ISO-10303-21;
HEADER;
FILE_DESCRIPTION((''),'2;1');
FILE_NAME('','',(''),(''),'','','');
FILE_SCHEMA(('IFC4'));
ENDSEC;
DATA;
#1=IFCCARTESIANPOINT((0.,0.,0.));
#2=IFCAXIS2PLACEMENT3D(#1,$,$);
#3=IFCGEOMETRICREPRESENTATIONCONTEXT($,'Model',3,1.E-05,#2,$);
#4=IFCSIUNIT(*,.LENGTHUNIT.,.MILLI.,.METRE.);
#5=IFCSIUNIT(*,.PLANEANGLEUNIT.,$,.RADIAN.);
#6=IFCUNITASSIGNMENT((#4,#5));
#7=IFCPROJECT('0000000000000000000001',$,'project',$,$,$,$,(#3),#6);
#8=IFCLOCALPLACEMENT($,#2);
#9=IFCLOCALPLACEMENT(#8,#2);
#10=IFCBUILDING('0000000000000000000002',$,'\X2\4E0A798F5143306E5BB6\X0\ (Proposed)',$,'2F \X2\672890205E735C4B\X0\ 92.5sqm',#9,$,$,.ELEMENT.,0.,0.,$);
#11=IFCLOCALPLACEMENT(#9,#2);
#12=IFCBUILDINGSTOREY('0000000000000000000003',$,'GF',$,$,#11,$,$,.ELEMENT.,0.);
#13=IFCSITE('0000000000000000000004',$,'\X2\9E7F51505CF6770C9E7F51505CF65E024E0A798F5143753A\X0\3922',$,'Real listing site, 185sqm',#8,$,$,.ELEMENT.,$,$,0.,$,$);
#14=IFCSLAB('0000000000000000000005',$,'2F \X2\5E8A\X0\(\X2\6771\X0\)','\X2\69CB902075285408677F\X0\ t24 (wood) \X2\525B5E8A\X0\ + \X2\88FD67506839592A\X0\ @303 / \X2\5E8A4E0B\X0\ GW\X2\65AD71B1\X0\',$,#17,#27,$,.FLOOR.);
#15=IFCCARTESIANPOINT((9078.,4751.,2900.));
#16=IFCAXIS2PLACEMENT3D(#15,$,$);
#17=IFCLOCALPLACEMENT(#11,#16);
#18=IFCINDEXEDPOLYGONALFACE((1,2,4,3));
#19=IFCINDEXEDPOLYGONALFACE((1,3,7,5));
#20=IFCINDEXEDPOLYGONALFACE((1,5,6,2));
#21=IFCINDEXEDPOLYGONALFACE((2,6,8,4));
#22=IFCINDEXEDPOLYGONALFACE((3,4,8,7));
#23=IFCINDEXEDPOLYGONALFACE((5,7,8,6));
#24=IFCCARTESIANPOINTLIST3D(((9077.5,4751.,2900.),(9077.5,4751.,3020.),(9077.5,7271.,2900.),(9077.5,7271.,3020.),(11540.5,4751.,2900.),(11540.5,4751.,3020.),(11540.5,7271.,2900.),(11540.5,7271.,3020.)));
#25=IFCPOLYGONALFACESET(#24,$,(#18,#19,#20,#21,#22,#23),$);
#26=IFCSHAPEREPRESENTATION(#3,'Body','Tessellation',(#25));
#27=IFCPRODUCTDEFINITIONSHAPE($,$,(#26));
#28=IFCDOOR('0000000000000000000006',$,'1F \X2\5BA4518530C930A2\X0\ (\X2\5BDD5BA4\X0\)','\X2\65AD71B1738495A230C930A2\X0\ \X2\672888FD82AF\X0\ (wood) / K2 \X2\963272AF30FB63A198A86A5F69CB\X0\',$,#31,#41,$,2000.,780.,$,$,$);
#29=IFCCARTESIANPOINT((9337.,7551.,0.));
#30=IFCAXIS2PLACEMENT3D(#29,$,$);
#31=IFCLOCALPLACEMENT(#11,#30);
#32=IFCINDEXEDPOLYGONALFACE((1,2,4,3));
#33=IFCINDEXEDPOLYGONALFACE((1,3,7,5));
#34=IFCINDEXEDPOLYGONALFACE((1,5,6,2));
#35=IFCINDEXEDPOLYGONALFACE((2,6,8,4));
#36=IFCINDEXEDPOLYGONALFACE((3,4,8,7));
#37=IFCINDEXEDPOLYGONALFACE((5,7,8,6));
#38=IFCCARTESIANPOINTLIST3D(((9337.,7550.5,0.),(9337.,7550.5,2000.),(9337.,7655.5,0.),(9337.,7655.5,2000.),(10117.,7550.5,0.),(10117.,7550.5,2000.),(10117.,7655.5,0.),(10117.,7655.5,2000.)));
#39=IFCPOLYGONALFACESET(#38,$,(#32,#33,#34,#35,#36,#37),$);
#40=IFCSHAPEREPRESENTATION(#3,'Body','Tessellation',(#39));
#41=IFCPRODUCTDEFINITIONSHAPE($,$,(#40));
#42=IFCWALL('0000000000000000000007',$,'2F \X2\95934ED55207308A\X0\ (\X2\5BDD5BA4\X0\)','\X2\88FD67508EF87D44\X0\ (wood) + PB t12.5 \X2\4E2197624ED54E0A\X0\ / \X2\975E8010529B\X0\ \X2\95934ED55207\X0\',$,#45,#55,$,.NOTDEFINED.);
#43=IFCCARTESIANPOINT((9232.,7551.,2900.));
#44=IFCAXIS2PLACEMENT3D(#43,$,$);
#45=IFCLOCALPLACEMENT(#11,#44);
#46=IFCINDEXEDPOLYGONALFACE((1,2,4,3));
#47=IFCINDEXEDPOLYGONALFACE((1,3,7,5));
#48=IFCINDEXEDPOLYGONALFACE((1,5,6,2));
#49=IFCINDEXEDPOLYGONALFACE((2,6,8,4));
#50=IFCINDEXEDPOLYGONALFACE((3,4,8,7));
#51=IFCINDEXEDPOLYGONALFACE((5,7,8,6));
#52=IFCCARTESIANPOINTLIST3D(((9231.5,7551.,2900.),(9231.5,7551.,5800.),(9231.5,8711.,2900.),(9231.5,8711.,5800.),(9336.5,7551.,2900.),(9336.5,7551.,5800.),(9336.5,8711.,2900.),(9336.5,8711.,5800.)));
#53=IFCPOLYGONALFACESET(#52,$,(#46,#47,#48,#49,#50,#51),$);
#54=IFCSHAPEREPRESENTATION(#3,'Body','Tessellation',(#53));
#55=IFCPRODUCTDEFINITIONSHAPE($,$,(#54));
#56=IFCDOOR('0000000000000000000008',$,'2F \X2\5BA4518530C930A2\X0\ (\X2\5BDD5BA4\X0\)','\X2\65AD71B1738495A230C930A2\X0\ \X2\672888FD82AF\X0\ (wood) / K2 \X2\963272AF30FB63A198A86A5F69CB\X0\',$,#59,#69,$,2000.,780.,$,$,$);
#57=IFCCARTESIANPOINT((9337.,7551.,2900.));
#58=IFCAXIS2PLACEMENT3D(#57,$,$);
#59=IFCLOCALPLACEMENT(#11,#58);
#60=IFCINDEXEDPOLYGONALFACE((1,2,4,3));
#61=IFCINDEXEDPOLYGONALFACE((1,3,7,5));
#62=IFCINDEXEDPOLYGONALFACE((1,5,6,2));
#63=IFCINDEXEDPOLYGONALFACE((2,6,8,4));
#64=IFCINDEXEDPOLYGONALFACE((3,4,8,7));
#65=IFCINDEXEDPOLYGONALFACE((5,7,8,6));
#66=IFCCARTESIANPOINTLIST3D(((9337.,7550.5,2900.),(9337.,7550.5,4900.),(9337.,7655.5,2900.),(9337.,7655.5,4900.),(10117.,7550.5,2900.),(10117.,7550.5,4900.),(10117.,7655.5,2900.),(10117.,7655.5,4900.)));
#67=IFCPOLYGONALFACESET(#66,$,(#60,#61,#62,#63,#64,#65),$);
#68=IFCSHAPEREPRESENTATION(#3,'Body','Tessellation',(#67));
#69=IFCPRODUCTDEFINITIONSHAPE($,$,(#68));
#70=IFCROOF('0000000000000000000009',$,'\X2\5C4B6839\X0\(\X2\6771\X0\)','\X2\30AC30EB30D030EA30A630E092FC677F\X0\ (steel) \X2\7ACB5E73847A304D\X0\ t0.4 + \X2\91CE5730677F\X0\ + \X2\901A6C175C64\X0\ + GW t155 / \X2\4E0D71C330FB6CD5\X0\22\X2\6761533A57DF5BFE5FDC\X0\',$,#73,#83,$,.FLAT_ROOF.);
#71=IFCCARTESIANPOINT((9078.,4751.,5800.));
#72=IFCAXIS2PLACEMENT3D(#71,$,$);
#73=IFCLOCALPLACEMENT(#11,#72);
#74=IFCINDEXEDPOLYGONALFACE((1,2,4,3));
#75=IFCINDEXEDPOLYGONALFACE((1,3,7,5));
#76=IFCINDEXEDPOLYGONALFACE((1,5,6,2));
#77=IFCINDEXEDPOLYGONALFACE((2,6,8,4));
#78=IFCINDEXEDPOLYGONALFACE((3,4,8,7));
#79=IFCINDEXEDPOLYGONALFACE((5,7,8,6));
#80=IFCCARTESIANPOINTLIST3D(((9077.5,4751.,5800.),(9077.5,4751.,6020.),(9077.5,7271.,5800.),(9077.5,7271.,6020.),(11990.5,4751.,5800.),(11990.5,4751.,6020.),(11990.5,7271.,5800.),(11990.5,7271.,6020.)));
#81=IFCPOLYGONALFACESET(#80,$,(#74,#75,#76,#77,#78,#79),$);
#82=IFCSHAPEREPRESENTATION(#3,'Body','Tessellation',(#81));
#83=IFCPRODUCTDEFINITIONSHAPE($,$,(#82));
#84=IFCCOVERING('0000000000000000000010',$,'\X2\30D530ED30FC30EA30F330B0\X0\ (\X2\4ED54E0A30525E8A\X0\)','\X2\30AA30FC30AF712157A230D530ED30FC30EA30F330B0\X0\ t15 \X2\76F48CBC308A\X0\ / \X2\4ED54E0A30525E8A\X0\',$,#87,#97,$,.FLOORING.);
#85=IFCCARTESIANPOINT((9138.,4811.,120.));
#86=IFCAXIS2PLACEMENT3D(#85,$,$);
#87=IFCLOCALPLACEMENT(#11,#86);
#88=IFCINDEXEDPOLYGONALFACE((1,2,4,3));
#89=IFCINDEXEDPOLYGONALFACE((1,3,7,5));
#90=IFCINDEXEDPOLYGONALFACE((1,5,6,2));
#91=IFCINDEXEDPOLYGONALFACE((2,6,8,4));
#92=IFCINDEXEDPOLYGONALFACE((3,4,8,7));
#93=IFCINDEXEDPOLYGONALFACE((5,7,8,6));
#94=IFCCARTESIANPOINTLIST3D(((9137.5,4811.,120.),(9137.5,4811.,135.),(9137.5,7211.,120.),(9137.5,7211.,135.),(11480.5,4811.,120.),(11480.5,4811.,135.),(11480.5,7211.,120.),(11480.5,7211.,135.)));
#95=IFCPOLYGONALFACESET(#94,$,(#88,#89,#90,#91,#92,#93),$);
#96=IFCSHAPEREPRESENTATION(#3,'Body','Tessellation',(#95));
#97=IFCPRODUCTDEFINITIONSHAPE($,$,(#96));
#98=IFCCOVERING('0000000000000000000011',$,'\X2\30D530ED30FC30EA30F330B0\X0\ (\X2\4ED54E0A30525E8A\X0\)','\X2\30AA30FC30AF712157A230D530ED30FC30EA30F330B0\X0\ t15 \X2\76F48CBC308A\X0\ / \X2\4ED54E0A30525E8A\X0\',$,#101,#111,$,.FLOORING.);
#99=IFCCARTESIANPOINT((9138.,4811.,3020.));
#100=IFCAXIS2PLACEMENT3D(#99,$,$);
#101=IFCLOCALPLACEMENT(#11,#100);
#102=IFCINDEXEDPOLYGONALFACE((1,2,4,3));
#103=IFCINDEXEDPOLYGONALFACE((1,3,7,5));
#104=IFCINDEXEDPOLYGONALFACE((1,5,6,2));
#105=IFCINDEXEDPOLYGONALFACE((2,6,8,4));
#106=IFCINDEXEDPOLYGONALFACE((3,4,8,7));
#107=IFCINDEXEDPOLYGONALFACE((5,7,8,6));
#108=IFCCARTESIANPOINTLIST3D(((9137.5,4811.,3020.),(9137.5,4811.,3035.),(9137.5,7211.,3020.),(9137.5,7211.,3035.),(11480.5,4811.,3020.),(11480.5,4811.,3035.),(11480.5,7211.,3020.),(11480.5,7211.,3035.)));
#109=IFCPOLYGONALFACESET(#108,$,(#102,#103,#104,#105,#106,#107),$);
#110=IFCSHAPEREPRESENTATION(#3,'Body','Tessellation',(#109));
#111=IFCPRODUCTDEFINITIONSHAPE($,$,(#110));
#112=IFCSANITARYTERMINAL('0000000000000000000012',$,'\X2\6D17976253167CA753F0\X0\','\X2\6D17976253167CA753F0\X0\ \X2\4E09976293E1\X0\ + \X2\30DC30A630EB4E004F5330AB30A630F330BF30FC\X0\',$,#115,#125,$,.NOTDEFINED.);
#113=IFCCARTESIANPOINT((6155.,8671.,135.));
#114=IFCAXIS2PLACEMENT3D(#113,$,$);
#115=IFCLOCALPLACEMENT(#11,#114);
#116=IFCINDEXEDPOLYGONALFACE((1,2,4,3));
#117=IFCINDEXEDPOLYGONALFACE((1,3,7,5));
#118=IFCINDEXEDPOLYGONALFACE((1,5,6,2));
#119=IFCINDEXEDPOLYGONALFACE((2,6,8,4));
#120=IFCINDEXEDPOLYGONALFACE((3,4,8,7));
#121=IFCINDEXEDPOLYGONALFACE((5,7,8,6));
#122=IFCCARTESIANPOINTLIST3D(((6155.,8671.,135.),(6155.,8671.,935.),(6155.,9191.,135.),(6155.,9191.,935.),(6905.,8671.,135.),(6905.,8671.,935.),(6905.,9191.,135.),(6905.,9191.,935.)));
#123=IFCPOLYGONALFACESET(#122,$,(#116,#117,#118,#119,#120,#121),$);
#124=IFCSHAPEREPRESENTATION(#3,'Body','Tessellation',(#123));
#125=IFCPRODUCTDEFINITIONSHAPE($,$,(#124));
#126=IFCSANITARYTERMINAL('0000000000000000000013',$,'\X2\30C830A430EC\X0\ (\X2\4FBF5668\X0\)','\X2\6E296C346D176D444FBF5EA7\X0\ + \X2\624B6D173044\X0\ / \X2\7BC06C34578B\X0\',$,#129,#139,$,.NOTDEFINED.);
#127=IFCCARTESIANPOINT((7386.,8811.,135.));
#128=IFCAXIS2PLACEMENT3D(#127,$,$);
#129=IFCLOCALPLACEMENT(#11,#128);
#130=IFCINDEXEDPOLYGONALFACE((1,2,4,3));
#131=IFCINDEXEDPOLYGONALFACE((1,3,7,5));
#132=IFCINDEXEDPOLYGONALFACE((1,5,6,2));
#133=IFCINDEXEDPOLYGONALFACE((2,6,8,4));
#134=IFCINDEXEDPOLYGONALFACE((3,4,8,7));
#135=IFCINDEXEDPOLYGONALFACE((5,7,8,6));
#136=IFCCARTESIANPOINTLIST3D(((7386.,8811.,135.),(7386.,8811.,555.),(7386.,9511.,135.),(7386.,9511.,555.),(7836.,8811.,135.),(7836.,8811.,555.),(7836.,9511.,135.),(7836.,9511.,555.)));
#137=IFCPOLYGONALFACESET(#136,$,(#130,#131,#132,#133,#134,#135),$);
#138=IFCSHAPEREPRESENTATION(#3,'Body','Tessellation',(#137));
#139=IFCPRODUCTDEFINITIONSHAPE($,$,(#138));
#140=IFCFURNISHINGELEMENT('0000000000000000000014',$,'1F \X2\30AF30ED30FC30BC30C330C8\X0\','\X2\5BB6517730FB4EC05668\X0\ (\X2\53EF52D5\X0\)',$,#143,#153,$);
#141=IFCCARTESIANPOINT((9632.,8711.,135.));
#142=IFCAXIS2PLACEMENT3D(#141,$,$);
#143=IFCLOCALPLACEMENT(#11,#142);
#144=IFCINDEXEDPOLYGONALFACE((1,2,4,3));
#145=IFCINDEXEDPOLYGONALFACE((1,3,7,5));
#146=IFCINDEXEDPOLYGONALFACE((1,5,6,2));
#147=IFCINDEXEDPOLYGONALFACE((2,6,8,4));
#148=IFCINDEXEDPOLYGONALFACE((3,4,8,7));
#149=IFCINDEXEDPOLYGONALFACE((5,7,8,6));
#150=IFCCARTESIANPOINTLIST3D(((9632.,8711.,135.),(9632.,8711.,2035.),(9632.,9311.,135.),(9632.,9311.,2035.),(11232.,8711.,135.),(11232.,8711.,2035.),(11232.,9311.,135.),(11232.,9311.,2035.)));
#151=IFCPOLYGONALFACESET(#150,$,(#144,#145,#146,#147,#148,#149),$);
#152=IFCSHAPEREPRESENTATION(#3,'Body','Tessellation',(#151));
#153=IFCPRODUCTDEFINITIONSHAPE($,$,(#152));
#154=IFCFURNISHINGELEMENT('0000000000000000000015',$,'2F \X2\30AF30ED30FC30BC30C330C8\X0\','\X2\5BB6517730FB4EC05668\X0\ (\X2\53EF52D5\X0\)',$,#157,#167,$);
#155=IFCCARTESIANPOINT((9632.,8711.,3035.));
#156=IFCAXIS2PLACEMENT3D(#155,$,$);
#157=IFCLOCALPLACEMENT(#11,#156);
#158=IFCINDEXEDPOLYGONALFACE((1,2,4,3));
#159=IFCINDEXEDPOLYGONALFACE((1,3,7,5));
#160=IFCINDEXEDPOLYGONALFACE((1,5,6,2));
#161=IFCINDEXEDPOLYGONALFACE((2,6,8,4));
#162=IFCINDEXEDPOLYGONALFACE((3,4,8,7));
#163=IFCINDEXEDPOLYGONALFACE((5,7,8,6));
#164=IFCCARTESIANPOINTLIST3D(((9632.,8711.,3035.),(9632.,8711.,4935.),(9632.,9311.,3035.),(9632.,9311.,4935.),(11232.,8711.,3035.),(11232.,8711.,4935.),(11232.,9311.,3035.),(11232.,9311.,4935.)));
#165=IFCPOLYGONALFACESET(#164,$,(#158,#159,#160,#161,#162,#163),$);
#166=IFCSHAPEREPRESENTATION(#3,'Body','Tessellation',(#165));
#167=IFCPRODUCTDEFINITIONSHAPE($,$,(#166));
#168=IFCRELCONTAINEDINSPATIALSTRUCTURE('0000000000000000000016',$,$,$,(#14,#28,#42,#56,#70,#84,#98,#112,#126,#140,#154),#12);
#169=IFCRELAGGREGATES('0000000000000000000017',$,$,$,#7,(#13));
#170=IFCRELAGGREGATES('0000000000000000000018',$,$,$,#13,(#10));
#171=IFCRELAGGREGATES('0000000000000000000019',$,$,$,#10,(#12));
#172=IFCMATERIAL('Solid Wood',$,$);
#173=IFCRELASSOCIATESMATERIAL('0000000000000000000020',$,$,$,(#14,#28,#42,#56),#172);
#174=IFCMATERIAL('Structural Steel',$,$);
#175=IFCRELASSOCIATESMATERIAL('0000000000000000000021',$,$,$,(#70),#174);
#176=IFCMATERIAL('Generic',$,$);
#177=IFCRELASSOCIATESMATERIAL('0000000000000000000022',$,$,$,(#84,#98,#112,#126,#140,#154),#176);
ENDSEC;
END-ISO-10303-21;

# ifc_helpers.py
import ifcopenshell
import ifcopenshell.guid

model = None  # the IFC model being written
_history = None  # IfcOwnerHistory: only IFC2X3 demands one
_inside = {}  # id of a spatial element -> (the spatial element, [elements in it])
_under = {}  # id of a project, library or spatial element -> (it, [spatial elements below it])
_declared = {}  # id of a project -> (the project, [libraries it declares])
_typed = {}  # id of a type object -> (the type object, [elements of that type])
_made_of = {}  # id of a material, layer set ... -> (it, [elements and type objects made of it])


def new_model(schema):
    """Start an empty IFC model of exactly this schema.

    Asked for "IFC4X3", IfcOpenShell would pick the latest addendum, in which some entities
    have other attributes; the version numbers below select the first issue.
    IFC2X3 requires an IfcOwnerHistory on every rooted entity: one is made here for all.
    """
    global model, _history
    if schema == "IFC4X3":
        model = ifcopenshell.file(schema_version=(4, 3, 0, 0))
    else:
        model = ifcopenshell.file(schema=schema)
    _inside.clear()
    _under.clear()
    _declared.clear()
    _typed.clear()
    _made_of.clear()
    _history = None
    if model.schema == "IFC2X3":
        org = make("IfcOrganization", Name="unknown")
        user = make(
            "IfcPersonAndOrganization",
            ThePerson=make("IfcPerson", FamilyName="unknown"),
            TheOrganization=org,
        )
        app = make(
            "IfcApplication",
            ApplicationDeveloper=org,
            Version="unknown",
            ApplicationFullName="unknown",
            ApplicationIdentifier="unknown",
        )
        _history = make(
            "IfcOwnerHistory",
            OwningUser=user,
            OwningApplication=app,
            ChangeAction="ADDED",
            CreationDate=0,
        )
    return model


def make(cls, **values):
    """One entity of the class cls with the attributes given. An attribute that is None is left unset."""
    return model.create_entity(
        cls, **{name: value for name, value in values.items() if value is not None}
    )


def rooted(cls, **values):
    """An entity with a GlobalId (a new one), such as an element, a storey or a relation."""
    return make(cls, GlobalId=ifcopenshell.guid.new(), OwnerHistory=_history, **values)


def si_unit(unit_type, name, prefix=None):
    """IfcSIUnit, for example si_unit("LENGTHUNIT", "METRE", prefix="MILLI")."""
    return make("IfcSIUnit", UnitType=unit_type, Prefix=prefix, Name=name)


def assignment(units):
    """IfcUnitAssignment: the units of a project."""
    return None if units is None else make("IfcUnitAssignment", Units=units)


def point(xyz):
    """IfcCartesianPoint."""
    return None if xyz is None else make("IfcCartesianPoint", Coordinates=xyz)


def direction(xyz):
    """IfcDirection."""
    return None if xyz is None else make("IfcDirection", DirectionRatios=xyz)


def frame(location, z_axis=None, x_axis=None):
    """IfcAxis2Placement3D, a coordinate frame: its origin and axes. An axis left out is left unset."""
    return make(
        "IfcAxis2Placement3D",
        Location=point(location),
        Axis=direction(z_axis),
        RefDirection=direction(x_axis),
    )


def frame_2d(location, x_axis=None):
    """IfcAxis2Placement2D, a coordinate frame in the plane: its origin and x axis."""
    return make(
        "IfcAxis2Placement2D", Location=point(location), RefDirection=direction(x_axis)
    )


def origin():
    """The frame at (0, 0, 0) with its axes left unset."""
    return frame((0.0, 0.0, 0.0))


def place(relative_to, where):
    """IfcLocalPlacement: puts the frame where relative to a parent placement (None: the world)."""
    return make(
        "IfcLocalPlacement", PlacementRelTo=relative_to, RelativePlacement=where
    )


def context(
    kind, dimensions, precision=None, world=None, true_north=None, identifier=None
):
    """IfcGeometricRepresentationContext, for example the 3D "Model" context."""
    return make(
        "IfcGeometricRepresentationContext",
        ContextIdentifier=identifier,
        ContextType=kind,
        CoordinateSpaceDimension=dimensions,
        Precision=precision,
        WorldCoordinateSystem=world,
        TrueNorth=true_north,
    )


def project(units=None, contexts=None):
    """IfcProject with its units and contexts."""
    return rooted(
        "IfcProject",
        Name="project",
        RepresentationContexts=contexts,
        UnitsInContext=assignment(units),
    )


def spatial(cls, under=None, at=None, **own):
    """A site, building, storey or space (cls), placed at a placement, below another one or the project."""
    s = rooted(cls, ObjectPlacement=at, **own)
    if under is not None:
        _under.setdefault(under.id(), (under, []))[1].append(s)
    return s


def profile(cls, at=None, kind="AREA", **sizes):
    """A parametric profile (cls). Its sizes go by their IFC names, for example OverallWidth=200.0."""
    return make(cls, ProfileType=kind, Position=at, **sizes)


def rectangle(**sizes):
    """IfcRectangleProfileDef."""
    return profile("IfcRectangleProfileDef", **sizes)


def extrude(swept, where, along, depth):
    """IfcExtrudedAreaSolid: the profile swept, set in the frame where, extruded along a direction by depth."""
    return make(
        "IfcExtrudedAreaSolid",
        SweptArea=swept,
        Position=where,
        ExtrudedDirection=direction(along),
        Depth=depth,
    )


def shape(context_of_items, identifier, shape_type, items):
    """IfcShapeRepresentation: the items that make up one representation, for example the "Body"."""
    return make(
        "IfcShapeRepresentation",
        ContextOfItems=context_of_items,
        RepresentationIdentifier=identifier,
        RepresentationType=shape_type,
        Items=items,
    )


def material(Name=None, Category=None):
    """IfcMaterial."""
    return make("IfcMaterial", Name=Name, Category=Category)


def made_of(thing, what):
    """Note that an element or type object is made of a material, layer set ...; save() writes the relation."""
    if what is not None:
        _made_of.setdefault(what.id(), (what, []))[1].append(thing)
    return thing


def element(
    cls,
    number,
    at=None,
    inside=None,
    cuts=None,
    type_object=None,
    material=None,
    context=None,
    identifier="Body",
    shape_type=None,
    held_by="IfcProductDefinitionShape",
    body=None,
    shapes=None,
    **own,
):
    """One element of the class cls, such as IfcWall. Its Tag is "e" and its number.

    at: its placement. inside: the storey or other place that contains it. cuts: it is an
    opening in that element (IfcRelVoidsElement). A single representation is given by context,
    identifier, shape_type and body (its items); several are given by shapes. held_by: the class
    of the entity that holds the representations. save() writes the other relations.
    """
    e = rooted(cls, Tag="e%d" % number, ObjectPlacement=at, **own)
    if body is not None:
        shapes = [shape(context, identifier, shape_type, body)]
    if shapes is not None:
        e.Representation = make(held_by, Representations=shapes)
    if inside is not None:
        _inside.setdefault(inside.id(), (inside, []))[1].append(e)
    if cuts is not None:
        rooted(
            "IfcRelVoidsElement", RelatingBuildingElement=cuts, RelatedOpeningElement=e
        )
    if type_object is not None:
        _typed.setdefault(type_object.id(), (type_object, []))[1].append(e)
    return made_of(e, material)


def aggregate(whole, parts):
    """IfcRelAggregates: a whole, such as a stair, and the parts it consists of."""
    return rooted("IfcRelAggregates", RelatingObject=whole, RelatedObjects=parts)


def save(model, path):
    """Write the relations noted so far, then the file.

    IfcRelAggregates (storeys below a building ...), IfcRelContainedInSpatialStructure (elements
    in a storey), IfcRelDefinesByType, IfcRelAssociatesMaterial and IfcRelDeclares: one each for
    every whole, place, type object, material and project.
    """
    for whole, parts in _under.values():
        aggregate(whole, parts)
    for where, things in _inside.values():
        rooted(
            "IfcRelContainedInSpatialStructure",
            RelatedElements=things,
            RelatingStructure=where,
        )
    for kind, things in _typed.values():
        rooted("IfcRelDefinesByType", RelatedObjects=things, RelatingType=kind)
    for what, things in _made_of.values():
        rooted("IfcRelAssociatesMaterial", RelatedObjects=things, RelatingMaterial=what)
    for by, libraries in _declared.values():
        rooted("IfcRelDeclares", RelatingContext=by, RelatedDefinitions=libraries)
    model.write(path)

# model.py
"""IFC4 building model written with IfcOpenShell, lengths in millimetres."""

from ifc_helpers import new_model, si_unit, frame, frame_2d, origin, place, context, project, spatial, rectangle, extrude, material, element, save


model = new_model("IFC4")

# Units and contexts
model_context = context("Model", 3, precision=1e-05, world=origin())
ifc_project = project(units=[si_unit("LENGTHUNIT", "METRE", prefix="MILLI"), si_unit("PLANEANGLEUNIT", "RADIAN")], contexts=[model_context])

# Site, building, storey
site_placement = place(None, origin())
site = spatial("IfcSite", under=ifc_project, at=site_placement, Name="鹿児島県鹿児島市上福元町3922", ObjectType="Real listing site, 185sqm", CompositionType="ELEMENT", RefElevation=0.0)
building_placement = place(site_placement, origin())
building = spatial("IfcBuilding", under=site, at=building_placement, Name="上福元の家 (Proposed)", ObjectType="2F 木造平屋 92.5sqm", CompositionType="ELEMENT", ElevationOfRefHeight=0.0, ElevationOfTerrain=0.0)
storey_placement = place(building_placement, origin())
storey = spatial("IfcBuildingStorey", under=building, at=storey_placement, Name="GF", CompositionType="ELEMENT", Elevation=0.0)

# Slab
ifc_material_1 = material(Name="Solid Wood")
slab_1_placement = place(storey_placement, frame((9078.0, 4751.0, 2900.0)))
element("IfcSlab", 1, at=slab_1_placement, inside=storey, material=ifc_material_1, Name="2F 床(東)", Description="構造用合板 t24 (wood) 剛床 + 製材根太 @303 / 床下 GW断熱", PredefinedType="FLOOR", context=model_context, shape_type="SweptSolid", body=[
    extrude(rectangle(XDim=2463.0, YDim=2520.0, at=frame_2d((1231.0, 1260.0))), frame((9078.0, 4751.0, 2900.0)), (0.0, 0.0, 1.0), 120.0),
])

# Door
door_1_placement = place(storey_placement, frame((9337.0, 7551.0, 0.0)))
element("IfcDoor", 2, at=door_1_placement, inside=storey, material=ifc_material_1, Name="1F 室内ドア (寝室)", Description="断熱玄関ドア 木製芯 (wood) / K2 防犯・採風機構", OverallHeight=2000.0, OverallWidth=780.0, context=model_context, shape_type="SweptSolid", body=[
    extrude(rectangle(XDim=780.0, YDim=105.0, at=frame_2d((390.0, 52.0))), frame((9337.0, 7551.0, 0.0)), (0.0, 0.0, 1.0), 2000.0),
])

# Wall
wall_1_placement = place(storey_placement, frame((9232.0, 7551.0, 2900.0)))
element("IfcWall", 3, at=wall_1_placement, inside=storey, material=ifc_material_1, Name="2F 間仕切り (寝室)", Description="製材軸組 (wood) + PB t12.5 両面仕上 / 非耐力 間仕切", PredefinedType="NOTDEFINED", context=model_context, shape_type="SweptSolid", body=[
    extrude(rectangle(XDim=105.0, YDim=1160.0, at=frame_2d((52.0, 580.0))), frame((9232.0, 7551.0, 2900.0)), (0.0, 0.0, 1.0), 2900.0),
])

# Door
door_2_placement = place(storey_placement, frame((9337.0, 7551.0, 2900.0)))
element("IfcDoor", 4, at=door_2_placement, inside=storey, material=ifc_material_1, Name="2F 室内ドア (寝室)", Description="断熱玄関ドア 木製芯 (wood) / K2 防犯・採風機構", OverallHeight=2000.0, OverallWidth=780.0, context=model_context, shape_type="SweptSolid", body=[
    extrude(rectangle(XDim=780.0, YDim=105.0, at=frame_2d((390.0, 52.0))), frame((9337.0, 7551.0, 2900.0)), (0.0, 0.0, 1.0), 2000.0),
])

# Roof
ifc_material_2 = material(Name="Structural Steel")
for number, where, name in (
    (5, (9078.0, 4751.0, 5800.0), "屋根(東)"),
):
    element("IfcRoof", number, at=place(storey_placement, frame(where)), inside=storey, material=ifc_material_2, Name=name, Description="ガルバリウム鋼板 (steel) 立平葺き t0.4 + 野地板 + 通気層 + GW t155 / 不燃・法22条区域対応", PredefinedType="FLAT_ROOF", context=model_context, shape_type="SweptSolid", body=[
        extrude(rectangle(XDim=2913.0, YDim=2520.0, at=frame_2d((1456.0, 1260.0))), frame((9078.0, 4751.0, 5800.0)), (0.0, 0.0, 1.0), 220.0),
    ])

# Coverings
ifc_material_3 = material(Name="Generic")
covering_1_placement = place(storey_placement, frame((9138.0, 4811.0, 120.0)))
element("IfcCovering", 6, at=covering_1_placement, inside=storey, material=ifc_material_3, Name="フローリング (仕上げ床)", Description="オーク無垢フローリング t15 直貼り / 仕上げ床", PredefinedType="FLOORING", context=model_context, shape_type="SweptSolid", body=[
    extrude(rectangle(XDim=2343.0, YDim=2400.0, at=frame_2d((1171.0, 1200.0))), frame((9138.0, 4811.0, 120.0)), (0.0, 0.0, 1.0), 15.0),
])
covering_2_placement = place(storey_placement, frame((9138.0, 4811.0, 3020.0)))
element("IfcCovering", 7, at=covering_2_placement, inside=storey, material=ifc_material_3, Name="フローリング (仕上げ床)", Description="オーク無垢フローリング t15 直貼り / 仕上げ床", PredefinedType="FLOORING", context=model_context, shape_type="SweptSolid", body=[
    extrude(rectangle(XDim=2343.0, YDim=2400.0, at=frame_2d((1171.0, 1200.0))), frame((9138.0, 4811.0, 3020.0)), (0.0, 0.0, 1.0), 15.0),
])

# Sanitary terminals
sanitary_terminal_1_placement = place(storey_placement, frame((6155.0, 8671.0, 135.0)))
element("IfcSanitaryTerminal", 8, at=sanitary_terminal_1_placement, inside=storey, material=ifc_material_3, Name="洗面化粧台", Description="洗面化粧台 三面鏡 + ボウル一体カウンター", PredefinedType="NOTDEFINED", context=model_context, shape_type="SweptSolid", body=[
    extrude(rectangle(XDim=750.0, YDim=520.0, at=frame_2d((375.0, 260.0))), frame((6155.0, 8671.0, 135.0)), (0.0, 0.0, 1.0), 800.0),
])
sanitary_terminal_2_placement = place(storey_placement, frame((7386.0, 8811.0, 135.0)))
element("IfcSanitaryTerminal", 9, at=sanitary_terminal_2_placement, inside=storey, material=ifc_material_3, Name="トイレ (便器)", Description="温水洗浄便座 + 手洗い / 節水型", PredefinedType="NOTDEFINED", context=model_context, shape_type="SweptSolid", body=[
    extrude(rectangle(XDim=450.0, YDim=700.0, at=frame_2d((225.0, 350.0))), frame((7386.0, 8811.0, 135.0)), (0.0, 0.0, 1.0), 420.0),
])

# Furnishing elements
furnishing_1_placement = place(storey_placement, frame((9632.0, 8711.0, 135.0)))
element("IfcFurnishingElement", 10, at=furnishing_1_placement, inside=storey, material=ifc_material_3, Name="1F クローゼット", Description="家具・什器 (可動)", context=model_context, shape_type="SweptSolid", body=[
    extrude(rectangle(XDim=1600.0, YDim=600.0, at=frame_2d((800.0, 300.0))), frame((9632.0, 8711.0, 135.0)), (0.0, 0.0, 1.0), 1900.0),
])
furnishing_2_placement = place(storey_placement, frame((9632.0, 8711.0, 3035.0)))
element("IfcFurnishingElement", 11, at=furnishing_2_placement, inside=storey, material=ifc_material_3, Name="2F クローゼット", Description="家具・什器 (可動)", context=model_context, shape_type="SweptSolid", body=[
    extrude(rectangle(XDim=1600.0, YDim=600.0, at=frame_2d((800.0, 300.0))), frame((9632.0, 8711.0, 3035.0)), (0.0, 0.0, 1.0), 1900.0),
])

save(model, "model.ifc")
